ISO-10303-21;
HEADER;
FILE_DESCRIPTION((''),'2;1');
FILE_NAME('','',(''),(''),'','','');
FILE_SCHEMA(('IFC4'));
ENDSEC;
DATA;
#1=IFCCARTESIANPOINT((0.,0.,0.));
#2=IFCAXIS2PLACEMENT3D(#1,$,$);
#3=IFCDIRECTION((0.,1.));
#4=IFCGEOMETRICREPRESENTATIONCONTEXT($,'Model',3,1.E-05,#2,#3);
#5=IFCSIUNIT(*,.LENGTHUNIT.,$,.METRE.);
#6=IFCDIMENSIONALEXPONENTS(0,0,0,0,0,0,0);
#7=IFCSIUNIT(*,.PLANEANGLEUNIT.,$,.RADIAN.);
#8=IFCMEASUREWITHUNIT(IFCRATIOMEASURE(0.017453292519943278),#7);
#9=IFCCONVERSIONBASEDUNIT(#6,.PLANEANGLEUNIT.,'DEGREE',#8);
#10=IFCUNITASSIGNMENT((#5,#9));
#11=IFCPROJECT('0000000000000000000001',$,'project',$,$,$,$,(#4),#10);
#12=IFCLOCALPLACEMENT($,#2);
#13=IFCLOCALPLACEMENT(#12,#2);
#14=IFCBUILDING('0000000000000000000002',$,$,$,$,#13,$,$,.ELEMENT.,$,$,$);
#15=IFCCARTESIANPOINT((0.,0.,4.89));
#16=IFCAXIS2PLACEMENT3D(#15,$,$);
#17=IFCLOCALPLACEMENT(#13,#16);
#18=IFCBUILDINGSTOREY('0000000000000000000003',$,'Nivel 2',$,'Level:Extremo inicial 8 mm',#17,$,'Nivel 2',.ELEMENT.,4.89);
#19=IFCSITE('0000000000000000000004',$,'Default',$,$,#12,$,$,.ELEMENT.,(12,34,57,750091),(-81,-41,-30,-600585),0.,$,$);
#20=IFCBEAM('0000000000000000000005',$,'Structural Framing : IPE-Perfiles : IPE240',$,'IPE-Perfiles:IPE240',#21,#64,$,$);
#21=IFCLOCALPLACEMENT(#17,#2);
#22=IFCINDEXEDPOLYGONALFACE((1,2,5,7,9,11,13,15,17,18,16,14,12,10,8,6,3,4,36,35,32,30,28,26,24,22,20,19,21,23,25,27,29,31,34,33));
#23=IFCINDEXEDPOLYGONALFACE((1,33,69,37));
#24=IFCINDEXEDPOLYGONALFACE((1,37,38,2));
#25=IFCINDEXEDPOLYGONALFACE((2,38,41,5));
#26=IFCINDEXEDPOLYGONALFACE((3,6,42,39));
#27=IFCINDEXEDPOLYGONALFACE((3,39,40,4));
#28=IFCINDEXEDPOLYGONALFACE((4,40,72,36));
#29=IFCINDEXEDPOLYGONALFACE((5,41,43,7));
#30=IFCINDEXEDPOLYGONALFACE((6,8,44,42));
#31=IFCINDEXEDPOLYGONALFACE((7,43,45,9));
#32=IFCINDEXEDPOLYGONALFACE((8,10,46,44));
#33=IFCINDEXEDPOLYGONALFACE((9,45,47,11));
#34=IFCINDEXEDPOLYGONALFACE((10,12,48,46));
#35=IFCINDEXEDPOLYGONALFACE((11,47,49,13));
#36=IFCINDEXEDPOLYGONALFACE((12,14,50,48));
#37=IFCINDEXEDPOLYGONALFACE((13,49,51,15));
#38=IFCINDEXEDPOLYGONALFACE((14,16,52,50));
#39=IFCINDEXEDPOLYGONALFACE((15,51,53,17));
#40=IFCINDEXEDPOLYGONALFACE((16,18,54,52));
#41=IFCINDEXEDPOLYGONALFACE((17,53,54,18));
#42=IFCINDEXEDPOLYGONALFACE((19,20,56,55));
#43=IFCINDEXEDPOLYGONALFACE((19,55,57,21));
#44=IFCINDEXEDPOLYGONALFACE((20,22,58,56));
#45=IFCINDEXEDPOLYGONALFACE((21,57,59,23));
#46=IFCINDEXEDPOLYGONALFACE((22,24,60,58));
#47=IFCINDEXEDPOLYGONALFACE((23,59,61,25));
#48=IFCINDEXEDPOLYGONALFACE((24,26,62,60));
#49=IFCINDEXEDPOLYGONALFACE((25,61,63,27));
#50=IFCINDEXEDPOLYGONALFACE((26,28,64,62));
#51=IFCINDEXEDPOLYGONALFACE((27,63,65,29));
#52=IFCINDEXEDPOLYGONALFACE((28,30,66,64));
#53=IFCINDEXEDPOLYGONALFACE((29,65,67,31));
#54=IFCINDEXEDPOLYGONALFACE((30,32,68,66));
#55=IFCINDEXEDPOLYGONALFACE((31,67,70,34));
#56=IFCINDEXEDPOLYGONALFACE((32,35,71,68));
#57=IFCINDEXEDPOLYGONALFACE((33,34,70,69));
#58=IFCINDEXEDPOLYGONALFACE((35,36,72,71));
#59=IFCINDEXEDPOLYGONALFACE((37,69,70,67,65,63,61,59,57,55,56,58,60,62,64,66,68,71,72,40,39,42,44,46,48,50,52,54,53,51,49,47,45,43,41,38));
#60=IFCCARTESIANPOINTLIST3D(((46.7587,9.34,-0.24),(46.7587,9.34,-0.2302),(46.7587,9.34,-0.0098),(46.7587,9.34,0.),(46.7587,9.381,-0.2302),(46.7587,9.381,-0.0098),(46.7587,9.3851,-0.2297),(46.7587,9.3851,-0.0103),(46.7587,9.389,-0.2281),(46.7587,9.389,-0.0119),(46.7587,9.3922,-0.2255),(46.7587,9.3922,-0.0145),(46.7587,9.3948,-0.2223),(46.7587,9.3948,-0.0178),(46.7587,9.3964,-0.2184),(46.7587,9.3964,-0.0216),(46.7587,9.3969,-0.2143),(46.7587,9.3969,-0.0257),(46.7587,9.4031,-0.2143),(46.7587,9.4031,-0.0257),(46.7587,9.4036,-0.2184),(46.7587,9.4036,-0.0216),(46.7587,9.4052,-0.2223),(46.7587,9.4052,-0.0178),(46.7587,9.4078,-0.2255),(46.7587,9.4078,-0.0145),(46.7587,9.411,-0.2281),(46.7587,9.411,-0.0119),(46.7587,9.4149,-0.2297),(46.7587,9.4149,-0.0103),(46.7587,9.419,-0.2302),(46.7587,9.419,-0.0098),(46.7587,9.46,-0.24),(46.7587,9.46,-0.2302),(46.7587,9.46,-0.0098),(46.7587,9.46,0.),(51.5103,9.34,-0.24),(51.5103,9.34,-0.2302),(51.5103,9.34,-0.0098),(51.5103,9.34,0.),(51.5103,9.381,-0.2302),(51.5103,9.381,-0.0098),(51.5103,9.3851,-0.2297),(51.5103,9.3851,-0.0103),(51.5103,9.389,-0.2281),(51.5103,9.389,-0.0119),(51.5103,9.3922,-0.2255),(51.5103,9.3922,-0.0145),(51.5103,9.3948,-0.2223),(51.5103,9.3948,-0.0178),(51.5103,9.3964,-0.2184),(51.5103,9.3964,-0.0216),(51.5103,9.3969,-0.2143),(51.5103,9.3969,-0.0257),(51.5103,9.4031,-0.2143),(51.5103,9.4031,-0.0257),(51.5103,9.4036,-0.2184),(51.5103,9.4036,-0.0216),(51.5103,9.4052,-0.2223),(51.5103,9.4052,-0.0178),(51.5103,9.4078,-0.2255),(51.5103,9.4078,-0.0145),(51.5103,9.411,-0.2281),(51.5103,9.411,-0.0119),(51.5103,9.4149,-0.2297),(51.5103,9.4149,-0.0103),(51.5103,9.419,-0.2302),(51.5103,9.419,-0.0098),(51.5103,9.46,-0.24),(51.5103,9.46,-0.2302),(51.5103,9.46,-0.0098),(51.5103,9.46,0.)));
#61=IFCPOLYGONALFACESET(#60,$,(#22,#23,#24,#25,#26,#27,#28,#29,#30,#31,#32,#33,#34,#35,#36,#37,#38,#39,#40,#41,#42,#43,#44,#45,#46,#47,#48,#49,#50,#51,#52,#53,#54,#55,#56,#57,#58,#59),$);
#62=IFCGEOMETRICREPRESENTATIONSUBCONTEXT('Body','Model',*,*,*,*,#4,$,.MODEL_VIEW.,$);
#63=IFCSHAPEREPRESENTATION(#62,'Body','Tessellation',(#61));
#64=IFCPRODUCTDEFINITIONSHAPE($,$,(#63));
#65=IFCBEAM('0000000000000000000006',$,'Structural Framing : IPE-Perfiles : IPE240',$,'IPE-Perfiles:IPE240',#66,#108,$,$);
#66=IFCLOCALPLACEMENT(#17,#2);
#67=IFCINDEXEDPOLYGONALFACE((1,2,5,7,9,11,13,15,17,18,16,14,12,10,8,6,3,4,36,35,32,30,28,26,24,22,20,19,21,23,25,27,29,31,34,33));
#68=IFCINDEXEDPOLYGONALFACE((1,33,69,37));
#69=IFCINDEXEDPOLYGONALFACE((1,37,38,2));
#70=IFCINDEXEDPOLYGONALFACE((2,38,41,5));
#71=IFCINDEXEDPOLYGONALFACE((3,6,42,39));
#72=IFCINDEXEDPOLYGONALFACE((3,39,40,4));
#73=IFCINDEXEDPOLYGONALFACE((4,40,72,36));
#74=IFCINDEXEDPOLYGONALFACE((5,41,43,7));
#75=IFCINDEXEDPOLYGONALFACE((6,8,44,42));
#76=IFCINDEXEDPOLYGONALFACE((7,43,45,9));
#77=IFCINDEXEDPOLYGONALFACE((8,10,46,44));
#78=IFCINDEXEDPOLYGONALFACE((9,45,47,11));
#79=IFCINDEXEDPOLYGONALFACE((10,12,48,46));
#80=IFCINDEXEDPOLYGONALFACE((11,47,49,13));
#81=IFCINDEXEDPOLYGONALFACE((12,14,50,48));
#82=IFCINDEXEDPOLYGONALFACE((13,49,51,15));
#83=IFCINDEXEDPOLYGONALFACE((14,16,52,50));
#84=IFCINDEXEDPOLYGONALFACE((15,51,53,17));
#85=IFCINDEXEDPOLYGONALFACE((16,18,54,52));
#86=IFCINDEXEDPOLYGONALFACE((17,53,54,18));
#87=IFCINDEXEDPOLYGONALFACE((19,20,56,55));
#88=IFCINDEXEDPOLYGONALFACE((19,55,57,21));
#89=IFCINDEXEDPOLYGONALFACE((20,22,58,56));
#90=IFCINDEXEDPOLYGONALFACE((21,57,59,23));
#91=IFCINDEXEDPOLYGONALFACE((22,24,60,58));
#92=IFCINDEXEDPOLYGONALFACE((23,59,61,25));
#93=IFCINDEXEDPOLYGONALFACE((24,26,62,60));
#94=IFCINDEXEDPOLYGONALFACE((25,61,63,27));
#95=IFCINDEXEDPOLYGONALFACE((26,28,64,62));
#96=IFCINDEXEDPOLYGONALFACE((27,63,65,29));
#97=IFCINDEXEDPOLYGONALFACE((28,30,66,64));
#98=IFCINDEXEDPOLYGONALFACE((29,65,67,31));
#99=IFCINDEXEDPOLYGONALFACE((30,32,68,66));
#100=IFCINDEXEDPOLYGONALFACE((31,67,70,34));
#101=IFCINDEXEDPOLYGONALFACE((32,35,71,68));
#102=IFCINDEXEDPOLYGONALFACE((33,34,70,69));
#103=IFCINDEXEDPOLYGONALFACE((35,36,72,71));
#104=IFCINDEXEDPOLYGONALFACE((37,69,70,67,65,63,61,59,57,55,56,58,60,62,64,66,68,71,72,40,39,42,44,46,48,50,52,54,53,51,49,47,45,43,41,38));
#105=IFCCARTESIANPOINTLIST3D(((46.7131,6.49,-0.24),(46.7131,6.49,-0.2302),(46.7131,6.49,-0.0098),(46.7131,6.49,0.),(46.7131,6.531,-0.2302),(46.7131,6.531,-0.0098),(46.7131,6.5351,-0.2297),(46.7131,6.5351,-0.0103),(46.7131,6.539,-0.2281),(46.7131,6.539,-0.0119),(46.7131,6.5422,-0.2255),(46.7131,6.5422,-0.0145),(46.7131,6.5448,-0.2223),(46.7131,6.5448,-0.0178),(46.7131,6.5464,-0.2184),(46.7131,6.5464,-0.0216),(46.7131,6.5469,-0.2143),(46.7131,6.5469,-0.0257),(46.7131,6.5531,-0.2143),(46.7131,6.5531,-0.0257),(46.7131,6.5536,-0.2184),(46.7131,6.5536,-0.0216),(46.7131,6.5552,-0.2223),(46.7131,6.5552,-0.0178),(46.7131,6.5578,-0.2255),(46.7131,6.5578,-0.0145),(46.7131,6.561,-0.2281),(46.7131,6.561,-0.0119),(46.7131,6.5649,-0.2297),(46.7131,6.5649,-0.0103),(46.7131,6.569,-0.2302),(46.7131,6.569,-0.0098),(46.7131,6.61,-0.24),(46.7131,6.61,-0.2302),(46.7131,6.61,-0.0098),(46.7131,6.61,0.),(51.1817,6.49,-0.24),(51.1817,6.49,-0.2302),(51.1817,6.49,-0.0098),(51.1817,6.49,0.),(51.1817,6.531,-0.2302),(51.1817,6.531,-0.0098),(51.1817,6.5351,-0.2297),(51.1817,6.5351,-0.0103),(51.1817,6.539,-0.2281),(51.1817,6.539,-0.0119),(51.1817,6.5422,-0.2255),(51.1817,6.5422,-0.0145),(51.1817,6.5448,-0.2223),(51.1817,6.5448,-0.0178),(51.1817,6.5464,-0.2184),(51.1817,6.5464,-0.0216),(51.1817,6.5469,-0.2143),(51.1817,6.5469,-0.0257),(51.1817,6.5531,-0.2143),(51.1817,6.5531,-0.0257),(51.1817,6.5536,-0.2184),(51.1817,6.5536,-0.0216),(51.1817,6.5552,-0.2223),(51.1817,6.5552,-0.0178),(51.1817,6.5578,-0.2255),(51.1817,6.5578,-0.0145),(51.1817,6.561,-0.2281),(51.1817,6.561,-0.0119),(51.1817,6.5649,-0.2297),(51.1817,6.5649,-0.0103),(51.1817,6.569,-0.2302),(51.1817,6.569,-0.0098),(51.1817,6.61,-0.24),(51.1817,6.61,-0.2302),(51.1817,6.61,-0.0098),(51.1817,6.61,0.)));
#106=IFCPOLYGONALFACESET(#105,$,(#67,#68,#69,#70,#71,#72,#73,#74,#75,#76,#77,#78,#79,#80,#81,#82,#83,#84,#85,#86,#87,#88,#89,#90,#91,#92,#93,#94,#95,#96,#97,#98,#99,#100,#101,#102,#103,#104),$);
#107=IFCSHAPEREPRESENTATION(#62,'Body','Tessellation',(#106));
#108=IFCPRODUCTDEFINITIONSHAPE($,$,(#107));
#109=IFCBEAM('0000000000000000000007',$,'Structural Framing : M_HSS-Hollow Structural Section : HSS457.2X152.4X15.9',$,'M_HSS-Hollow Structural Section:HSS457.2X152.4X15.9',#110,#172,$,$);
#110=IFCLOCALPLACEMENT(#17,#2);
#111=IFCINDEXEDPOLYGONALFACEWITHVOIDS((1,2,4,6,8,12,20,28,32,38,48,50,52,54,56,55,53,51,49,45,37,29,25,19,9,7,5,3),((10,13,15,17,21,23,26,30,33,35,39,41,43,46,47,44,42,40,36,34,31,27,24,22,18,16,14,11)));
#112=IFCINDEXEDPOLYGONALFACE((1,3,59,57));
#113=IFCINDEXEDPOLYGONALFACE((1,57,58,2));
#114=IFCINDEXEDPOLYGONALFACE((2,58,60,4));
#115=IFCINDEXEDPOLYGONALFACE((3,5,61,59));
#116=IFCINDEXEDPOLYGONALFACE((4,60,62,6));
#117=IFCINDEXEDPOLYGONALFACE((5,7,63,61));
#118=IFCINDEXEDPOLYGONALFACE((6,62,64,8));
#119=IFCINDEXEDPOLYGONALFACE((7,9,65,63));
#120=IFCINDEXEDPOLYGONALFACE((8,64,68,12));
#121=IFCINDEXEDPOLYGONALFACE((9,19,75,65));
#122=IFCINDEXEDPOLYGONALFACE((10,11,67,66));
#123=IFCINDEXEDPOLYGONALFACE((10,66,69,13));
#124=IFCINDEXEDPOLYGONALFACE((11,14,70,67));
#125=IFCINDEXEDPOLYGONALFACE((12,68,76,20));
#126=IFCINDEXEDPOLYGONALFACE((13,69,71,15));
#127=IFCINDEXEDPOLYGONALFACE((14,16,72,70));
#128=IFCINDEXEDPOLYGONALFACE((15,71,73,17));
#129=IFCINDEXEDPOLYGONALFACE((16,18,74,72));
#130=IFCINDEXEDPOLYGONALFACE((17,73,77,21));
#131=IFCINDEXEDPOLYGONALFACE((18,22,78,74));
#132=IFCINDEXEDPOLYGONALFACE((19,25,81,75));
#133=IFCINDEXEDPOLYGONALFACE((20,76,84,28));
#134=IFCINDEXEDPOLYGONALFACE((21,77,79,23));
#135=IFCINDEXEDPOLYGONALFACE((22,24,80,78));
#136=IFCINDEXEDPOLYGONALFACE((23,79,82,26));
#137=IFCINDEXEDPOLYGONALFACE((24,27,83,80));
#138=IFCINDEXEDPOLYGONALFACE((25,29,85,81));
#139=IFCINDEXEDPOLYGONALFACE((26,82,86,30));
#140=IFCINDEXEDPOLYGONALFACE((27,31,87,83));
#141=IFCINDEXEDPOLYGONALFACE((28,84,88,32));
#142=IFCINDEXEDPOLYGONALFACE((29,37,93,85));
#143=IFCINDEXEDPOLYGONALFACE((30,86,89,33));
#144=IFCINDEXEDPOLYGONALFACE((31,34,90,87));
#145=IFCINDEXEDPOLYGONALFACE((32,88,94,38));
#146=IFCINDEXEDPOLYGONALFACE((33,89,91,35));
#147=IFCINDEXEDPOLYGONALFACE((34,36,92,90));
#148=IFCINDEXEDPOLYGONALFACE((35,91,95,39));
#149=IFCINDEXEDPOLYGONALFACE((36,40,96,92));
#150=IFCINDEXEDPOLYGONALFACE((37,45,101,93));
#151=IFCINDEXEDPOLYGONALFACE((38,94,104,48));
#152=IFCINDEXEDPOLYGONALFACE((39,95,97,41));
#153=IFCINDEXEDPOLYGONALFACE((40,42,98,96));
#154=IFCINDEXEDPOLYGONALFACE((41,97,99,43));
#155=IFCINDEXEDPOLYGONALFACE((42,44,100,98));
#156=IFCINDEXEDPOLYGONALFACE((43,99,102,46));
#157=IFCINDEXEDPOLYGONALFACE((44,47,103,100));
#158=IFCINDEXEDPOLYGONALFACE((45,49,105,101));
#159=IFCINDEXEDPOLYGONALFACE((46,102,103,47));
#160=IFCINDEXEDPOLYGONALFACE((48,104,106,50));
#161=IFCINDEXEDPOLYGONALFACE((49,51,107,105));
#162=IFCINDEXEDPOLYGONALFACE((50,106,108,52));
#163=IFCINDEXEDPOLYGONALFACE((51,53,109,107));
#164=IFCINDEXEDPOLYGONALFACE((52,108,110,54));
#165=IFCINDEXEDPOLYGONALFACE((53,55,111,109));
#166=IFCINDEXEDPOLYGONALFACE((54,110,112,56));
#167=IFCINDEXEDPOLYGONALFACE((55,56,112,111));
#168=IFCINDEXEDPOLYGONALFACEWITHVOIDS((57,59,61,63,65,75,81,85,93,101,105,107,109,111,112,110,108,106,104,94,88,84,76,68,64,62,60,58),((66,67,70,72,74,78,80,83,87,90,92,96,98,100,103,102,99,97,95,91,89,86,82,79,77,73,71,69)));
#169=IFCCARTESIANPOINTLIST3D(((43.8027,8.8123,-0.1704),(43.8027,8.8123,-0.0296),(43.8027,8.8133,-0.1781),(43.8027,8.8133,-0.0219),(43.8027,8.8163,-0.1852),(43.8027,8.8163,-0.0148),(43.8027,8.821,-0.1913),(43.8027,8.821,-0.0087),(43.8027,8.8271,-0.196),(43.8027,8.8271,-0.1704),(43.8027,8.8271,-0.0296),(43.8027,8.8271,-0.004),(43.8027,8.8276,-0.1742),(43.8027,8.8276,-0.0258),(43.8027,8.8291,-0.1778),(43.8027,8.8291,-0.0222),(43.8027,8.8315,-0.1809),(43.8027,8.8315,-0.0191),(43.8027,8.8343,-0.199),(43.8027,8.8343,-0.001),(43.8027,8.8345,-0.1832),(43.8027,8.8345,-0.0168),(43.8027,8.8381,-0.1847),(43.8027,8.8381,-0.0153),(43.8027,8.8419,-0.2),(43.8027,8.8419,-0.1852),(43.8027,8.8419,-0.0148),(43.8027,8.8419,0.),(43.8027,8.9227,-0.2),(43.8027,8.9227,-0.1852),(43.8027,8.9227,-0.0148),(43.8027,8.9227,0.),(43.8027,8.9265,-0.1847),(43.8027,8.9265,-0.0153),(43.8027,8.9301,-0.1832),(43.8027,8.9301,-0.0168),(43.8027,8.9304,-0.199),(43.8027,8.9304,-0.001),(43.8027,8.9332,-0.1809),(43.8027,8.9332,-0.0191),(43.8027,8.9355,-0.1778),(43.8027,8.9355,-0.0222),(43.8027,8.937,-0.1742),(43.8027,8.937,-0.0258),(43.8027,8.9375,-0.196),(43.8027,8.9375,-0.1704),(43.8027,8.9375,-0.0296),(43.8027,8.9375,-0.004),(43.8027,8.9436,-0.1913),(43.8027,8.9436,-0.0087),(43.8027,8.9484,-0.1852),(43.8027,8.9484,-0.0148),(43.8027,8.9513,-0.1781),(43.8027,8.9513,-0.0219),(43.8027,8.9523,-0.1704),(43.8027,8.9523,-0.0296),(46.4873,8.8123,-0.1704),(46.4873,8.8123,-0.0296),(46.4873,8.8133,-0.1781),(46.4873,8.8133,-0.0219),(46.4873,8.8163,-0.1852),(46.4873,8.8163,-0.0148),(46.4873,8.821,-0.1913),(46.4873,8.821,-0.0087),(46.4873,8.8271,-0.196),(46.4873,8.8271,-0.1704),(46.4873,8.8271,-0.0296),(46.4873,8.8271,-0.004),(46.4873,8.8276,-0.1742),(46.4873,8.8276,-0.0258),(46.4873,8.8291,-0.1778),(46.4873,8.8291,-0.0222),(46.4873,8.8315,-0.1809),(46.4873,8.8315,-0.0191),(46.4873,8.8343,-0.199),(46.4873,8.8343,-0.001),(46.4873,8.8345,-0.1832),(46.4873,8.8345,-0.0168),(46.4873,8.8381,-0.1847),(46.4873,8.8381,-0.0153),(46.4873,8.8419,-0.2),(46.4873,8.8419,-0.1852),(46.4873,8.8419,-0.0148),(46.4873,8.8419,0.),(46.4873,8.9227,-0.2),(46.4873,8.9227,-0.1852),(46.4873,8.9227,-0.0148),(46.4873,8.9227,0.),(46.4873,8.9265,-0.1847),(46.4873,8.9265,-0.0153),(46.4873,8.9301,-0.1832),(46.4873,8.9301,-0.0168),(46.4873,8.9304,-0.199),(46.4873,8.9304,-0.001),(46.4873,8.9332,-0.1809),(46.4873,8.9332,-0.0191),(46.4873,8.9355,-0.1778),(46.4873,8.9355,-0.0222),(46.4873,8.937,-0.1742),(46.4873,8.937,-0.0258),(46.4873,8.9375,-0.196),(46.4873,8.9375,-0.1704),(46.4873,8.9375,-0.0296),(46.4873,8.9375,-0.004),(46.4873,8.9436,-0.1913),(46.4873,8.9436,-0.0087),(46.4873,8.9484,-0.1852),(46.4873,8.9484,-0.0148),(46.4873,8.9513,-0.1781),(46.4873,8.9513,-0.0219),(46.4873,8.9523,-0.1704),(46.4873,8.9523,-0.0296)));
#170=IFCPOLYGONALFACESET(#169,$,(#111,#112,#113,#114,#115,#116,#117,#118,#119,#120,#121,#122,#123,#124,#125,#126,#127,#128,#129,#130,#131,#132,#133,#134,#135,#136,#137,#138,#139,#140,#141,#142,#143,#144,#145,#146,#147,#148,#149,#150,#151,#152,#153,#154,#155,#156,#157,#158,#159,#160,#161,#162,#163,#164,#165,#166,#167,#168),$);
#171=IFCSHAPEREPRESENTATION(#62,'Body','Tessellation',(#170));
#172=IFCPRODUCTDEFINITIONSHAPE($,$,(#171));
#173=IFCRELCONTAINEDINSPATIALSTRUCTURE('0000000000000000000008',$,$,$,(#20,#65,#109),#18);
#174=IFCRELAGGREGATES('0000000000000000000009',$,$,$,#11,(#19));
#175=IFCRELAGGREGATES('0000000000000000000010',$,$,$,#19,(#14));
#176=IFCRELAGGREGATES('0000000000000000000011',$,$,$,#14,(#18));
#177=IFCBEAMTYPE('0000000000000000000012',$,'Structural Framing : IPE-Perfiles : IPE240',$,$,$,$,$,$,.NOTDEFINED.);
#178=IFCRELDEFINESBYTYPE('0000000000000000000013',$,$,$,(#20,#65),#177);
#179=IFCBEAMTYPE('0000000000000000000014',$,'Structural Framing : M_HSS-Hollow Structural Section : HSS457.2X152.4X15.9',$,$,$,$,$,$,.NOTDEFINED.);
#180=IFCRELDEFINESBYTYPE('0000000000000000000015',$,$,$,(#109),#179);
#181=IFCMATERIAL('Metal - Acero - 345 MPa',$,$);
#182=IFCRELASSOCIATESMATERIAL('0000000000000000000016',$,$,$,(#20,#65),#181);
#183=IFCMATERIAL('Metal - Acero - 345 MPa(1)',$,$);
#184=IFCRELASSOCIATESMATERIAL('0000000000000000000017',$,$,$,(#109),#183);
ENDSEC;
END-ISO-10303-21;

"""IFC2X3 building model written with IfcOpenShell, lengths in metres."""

from ifc_helpers import new_model, entity, si_unit, converted_unit, direction, frame, frame_2d, origin, place, context, subcontext, project, spatial, polyline, circle_curve, parameter, trimmed, segment, composite_curve, i_section, outline, extrude, material, type_object, element, save


model = new_model("IFC2X3")

# Units and contexts
model_context = context("Model", 3, precision=1e-05, world=origin(), true_north=direction((0.0, 1.0)))
body_context = subcontext(model_context, "Body", "Model", "MODEL_VIEW")
ifc_project = project(units=[si_unit("LENGTHUNIT", "METRE"), converted_unit("PLANEANGLEUNIT", "DEGREE", entity("IfcRatioMeasure", 0.017453292519943278), si_unit("PLANEANGLEUNIT", "RADIAN"), dimensions=[0, 0, 0, 0, 0, 0, 0])], contexts=[model_context])

# Site, building, storey
site_placement = place(None, origin())
site = spatial("IfcSite", under=ifc_project, at=site_placement, Name="Default", CompositionType="ELEMENT", RefLatitude=(12, 34, 57, 750091), RefLongitude=(-81, -41, -30, -600585), RefElevation=0.0)
building_placement = place(site_placement, origin())
building = spatial("IfcBuilding", under=site, at=building_placement, CompositionType="ELEMENT")
storey_placement = place(building_placement, frame((0.0, 0.0, 4.89)))
storey = spatial("IfcBuildingStorey", under=building, at=storey_placement, Name="Nivel 2", ObjectType="Level:Extremo inicial 8 mm", LongName="Nivel 2", CompositionType="ELEMENT", Elevation=4.89)

# Shared definitions
ifc_material_1 = material(Name="Metal - Acero - 345 MPa")
ifc_material_2 = material(Name="Metal - Acero - 345 MPa(1)")

# Beams
beam_type_1 = type_object("IfcBeamType", Name="Structural Framing : IPE-Perfiles : IPE240", PredefinedType="NOTDEFINED")
beam_1_placement = place(storey_placement, frame((46.745, 9.4, 0.0)))
element("IfcBeam", 1, at=beam_1_placement, inside=storey, type_object=beam_type_1, material=ifc_material_1, Name="Structural Framing : IPE-Perfiles : IPE240", ObjectType="IPE-Perfiles:IPE240", context=body_context, shape_type="SweptSolid", body=[
    extrude(i_section(OverallWidth=0.12, OverallDepth=0.24, WebThickness=0.0062, FlangeThickness=0.0098, FilletRadius=0.0159, at=frame_2d((0.0, 0.0), x_axis=(0.0, 1.0))), frame((0.0137, 0.0, -0.12), z_axis=(1.0, 0.0, 0.0), x_axis=(0.0, 0.0, -1.0)), (0.0, 0.0, 1.0), 4.7516),
])
beam_2_placement = place(storey_placement, frame((46.55, 6.55, 0.0)))
element("IfcBeam", 2, at=beam_2_placement, inside=storey, type_object=beam_type_1, material=ifc_material_1, Name="Structural Framing : IPE-Perfiles : IPE240", ObjectType="IPE-Perfiles:IPE240", context=body_context, shape_type="SweptSolid", body=[
    extrude(i_section(OverallWidth=0.12, OverallDepth=0.24, WebThickness=0.0062, FlangeThickness=0.0098, FilletRadius=0.0159, at=frame_2d((0.0, 0.0), x_axis=(0.0, 1.0))), frame((0.1631, 0.0, -0.12), z_axis=(1.0, 0.0, 0.0), x_axis=(0.0, 0.0, -1.0)), (0.0, 0.0, 1.0), 4.4686),
])
beam_type_2 = type_object("IfcBeamType", Name="Structural Framing : M_HSS-Hollow Structural Section : HSS457.2X152.4X15.9", PredefinedType="NOTDEFINED")
beam_3_placement = place(storey_placement, frame((43.74, 8.8823, 0.0)))
element("IfcBeam", 3, at=beam_3_placement, inside=storey, type_object=beam_type_2, material=ifc_material_2, Name="Structural Framing : M_HSS-Hollow Structural Section : HSS457.2X152.4X15.9", ObjectType="M_HSS-Hollow Structural Section:HSS457.2X152.4X15.9", context=body_context, shape_type="SweptSolid", body=[
    extrude(outline(composite_curve([segment(trimmed(circle_curve(frame_2d((-0.0404, -0.0704), x_axis=(1.0, 0.0)), 0.0296), [parameter(180.0)], [parameter(270.0)], True, "PARAMETER"), True, "CONTINUOUS"), segment(polyline([(-0.0404, -0.1), (0.0404, -0.1)]), True, "CONTINUOUS"), segment(trimmed(circle_curve(frame_2d((0.0404, -0.0704), x_axis=(1.0, 0.0)), 0.0296), [parameter(270.0)], [parameter(0.0)], True, "PARAMETER"), True, "CONTINUOUS"), segment(polyline([(0.07, -0.0704), (0.07, 0.0704)]), True, "CONTINUOUS"), segment(trimmed(circle_curve(frame_2d((0.0404, 0.0704), x_axis=(1.0, 0.0)), 0.0296), [parameter(360.0)], [parameter(90.0)], True, "PARAMETER"), True, "CONTINUOUS"), segment(polyline([(0.0404, 0.1), (-0.0404, 0.1)]), True, "CONTINUOUS"), segment(trimmed(circle_curve(frame_2d((-0.0404, 0.0704), x_axis=(1.0, 0.0)), 0.0296), [parameter(90.0)], [parameter(180.0)], True, "PARAMETER"), True, "CONTINUOUS"), segment(polyline([(-0.07, 0.0704), (-0.07, -0.0704)]), True, "CONTINUOUS")], self_intersect=False), holes=[composite_curve([segment(polyline([(0.0404, -0.0852), (-0.0404, -0.0852)]), True, "CONTINUOUS"), segment(trimmed(circle_curve(frame_2d((-0.0404, -0.0704), x_axis=(1.0, 0.0)), 0.0148), [parameter(180.0)], [parameter(270.0)], True, "PARAMETER"), False, "CONTINUOUS"), segment(polyline([(-0.0552, -0.0704), (-0.0552, 0.0704)]), True, "CONTINUOUS"), segment(trimmed(circle_curve(frame_2d((-0.0404, 0.0704), x_axis=(1.0, 0.0)), 0.0148), [parameter(90.0)], [parameter(180.0)], True, "PARAMETER"), False, "CONTINUOUS"), segment(polyline([(-0.0404, 0.0852), (0.0404, 0.0852)]), True, "CONTINUOUS"), segment(trimmed(circle_curve(frame_2d((0.0404, 0.0704), x_axis=(1.0, 0.0)), 0.0148), [parameter(0.0)], [parameter(90.0)], True, "PARAMETER"), False, "CONTINUOUS"), segment(polyline([(0.0552, 0.0704), (0.0552, -0.0704)]), True, "CONTINUOUS"), segment(trimmed(circle_curve(frame_2d((0.0404, -0.0704), x_axis=(1.0, 0.0)), 0.0148), [parameter(270.0)], [parameter(0.0)], True, "PARAMETER"), False, "CONTINUOUS")], self_intersect=False)]), frame((0.0627, 0.0, -0.1), z_axis=(1.0, 0.0, 0.0), x_axis=(0.0, -1.0, 0.0)), (0.0, 0.0, 1.0), 2.6846),
])

save(model, "model.ifc")
